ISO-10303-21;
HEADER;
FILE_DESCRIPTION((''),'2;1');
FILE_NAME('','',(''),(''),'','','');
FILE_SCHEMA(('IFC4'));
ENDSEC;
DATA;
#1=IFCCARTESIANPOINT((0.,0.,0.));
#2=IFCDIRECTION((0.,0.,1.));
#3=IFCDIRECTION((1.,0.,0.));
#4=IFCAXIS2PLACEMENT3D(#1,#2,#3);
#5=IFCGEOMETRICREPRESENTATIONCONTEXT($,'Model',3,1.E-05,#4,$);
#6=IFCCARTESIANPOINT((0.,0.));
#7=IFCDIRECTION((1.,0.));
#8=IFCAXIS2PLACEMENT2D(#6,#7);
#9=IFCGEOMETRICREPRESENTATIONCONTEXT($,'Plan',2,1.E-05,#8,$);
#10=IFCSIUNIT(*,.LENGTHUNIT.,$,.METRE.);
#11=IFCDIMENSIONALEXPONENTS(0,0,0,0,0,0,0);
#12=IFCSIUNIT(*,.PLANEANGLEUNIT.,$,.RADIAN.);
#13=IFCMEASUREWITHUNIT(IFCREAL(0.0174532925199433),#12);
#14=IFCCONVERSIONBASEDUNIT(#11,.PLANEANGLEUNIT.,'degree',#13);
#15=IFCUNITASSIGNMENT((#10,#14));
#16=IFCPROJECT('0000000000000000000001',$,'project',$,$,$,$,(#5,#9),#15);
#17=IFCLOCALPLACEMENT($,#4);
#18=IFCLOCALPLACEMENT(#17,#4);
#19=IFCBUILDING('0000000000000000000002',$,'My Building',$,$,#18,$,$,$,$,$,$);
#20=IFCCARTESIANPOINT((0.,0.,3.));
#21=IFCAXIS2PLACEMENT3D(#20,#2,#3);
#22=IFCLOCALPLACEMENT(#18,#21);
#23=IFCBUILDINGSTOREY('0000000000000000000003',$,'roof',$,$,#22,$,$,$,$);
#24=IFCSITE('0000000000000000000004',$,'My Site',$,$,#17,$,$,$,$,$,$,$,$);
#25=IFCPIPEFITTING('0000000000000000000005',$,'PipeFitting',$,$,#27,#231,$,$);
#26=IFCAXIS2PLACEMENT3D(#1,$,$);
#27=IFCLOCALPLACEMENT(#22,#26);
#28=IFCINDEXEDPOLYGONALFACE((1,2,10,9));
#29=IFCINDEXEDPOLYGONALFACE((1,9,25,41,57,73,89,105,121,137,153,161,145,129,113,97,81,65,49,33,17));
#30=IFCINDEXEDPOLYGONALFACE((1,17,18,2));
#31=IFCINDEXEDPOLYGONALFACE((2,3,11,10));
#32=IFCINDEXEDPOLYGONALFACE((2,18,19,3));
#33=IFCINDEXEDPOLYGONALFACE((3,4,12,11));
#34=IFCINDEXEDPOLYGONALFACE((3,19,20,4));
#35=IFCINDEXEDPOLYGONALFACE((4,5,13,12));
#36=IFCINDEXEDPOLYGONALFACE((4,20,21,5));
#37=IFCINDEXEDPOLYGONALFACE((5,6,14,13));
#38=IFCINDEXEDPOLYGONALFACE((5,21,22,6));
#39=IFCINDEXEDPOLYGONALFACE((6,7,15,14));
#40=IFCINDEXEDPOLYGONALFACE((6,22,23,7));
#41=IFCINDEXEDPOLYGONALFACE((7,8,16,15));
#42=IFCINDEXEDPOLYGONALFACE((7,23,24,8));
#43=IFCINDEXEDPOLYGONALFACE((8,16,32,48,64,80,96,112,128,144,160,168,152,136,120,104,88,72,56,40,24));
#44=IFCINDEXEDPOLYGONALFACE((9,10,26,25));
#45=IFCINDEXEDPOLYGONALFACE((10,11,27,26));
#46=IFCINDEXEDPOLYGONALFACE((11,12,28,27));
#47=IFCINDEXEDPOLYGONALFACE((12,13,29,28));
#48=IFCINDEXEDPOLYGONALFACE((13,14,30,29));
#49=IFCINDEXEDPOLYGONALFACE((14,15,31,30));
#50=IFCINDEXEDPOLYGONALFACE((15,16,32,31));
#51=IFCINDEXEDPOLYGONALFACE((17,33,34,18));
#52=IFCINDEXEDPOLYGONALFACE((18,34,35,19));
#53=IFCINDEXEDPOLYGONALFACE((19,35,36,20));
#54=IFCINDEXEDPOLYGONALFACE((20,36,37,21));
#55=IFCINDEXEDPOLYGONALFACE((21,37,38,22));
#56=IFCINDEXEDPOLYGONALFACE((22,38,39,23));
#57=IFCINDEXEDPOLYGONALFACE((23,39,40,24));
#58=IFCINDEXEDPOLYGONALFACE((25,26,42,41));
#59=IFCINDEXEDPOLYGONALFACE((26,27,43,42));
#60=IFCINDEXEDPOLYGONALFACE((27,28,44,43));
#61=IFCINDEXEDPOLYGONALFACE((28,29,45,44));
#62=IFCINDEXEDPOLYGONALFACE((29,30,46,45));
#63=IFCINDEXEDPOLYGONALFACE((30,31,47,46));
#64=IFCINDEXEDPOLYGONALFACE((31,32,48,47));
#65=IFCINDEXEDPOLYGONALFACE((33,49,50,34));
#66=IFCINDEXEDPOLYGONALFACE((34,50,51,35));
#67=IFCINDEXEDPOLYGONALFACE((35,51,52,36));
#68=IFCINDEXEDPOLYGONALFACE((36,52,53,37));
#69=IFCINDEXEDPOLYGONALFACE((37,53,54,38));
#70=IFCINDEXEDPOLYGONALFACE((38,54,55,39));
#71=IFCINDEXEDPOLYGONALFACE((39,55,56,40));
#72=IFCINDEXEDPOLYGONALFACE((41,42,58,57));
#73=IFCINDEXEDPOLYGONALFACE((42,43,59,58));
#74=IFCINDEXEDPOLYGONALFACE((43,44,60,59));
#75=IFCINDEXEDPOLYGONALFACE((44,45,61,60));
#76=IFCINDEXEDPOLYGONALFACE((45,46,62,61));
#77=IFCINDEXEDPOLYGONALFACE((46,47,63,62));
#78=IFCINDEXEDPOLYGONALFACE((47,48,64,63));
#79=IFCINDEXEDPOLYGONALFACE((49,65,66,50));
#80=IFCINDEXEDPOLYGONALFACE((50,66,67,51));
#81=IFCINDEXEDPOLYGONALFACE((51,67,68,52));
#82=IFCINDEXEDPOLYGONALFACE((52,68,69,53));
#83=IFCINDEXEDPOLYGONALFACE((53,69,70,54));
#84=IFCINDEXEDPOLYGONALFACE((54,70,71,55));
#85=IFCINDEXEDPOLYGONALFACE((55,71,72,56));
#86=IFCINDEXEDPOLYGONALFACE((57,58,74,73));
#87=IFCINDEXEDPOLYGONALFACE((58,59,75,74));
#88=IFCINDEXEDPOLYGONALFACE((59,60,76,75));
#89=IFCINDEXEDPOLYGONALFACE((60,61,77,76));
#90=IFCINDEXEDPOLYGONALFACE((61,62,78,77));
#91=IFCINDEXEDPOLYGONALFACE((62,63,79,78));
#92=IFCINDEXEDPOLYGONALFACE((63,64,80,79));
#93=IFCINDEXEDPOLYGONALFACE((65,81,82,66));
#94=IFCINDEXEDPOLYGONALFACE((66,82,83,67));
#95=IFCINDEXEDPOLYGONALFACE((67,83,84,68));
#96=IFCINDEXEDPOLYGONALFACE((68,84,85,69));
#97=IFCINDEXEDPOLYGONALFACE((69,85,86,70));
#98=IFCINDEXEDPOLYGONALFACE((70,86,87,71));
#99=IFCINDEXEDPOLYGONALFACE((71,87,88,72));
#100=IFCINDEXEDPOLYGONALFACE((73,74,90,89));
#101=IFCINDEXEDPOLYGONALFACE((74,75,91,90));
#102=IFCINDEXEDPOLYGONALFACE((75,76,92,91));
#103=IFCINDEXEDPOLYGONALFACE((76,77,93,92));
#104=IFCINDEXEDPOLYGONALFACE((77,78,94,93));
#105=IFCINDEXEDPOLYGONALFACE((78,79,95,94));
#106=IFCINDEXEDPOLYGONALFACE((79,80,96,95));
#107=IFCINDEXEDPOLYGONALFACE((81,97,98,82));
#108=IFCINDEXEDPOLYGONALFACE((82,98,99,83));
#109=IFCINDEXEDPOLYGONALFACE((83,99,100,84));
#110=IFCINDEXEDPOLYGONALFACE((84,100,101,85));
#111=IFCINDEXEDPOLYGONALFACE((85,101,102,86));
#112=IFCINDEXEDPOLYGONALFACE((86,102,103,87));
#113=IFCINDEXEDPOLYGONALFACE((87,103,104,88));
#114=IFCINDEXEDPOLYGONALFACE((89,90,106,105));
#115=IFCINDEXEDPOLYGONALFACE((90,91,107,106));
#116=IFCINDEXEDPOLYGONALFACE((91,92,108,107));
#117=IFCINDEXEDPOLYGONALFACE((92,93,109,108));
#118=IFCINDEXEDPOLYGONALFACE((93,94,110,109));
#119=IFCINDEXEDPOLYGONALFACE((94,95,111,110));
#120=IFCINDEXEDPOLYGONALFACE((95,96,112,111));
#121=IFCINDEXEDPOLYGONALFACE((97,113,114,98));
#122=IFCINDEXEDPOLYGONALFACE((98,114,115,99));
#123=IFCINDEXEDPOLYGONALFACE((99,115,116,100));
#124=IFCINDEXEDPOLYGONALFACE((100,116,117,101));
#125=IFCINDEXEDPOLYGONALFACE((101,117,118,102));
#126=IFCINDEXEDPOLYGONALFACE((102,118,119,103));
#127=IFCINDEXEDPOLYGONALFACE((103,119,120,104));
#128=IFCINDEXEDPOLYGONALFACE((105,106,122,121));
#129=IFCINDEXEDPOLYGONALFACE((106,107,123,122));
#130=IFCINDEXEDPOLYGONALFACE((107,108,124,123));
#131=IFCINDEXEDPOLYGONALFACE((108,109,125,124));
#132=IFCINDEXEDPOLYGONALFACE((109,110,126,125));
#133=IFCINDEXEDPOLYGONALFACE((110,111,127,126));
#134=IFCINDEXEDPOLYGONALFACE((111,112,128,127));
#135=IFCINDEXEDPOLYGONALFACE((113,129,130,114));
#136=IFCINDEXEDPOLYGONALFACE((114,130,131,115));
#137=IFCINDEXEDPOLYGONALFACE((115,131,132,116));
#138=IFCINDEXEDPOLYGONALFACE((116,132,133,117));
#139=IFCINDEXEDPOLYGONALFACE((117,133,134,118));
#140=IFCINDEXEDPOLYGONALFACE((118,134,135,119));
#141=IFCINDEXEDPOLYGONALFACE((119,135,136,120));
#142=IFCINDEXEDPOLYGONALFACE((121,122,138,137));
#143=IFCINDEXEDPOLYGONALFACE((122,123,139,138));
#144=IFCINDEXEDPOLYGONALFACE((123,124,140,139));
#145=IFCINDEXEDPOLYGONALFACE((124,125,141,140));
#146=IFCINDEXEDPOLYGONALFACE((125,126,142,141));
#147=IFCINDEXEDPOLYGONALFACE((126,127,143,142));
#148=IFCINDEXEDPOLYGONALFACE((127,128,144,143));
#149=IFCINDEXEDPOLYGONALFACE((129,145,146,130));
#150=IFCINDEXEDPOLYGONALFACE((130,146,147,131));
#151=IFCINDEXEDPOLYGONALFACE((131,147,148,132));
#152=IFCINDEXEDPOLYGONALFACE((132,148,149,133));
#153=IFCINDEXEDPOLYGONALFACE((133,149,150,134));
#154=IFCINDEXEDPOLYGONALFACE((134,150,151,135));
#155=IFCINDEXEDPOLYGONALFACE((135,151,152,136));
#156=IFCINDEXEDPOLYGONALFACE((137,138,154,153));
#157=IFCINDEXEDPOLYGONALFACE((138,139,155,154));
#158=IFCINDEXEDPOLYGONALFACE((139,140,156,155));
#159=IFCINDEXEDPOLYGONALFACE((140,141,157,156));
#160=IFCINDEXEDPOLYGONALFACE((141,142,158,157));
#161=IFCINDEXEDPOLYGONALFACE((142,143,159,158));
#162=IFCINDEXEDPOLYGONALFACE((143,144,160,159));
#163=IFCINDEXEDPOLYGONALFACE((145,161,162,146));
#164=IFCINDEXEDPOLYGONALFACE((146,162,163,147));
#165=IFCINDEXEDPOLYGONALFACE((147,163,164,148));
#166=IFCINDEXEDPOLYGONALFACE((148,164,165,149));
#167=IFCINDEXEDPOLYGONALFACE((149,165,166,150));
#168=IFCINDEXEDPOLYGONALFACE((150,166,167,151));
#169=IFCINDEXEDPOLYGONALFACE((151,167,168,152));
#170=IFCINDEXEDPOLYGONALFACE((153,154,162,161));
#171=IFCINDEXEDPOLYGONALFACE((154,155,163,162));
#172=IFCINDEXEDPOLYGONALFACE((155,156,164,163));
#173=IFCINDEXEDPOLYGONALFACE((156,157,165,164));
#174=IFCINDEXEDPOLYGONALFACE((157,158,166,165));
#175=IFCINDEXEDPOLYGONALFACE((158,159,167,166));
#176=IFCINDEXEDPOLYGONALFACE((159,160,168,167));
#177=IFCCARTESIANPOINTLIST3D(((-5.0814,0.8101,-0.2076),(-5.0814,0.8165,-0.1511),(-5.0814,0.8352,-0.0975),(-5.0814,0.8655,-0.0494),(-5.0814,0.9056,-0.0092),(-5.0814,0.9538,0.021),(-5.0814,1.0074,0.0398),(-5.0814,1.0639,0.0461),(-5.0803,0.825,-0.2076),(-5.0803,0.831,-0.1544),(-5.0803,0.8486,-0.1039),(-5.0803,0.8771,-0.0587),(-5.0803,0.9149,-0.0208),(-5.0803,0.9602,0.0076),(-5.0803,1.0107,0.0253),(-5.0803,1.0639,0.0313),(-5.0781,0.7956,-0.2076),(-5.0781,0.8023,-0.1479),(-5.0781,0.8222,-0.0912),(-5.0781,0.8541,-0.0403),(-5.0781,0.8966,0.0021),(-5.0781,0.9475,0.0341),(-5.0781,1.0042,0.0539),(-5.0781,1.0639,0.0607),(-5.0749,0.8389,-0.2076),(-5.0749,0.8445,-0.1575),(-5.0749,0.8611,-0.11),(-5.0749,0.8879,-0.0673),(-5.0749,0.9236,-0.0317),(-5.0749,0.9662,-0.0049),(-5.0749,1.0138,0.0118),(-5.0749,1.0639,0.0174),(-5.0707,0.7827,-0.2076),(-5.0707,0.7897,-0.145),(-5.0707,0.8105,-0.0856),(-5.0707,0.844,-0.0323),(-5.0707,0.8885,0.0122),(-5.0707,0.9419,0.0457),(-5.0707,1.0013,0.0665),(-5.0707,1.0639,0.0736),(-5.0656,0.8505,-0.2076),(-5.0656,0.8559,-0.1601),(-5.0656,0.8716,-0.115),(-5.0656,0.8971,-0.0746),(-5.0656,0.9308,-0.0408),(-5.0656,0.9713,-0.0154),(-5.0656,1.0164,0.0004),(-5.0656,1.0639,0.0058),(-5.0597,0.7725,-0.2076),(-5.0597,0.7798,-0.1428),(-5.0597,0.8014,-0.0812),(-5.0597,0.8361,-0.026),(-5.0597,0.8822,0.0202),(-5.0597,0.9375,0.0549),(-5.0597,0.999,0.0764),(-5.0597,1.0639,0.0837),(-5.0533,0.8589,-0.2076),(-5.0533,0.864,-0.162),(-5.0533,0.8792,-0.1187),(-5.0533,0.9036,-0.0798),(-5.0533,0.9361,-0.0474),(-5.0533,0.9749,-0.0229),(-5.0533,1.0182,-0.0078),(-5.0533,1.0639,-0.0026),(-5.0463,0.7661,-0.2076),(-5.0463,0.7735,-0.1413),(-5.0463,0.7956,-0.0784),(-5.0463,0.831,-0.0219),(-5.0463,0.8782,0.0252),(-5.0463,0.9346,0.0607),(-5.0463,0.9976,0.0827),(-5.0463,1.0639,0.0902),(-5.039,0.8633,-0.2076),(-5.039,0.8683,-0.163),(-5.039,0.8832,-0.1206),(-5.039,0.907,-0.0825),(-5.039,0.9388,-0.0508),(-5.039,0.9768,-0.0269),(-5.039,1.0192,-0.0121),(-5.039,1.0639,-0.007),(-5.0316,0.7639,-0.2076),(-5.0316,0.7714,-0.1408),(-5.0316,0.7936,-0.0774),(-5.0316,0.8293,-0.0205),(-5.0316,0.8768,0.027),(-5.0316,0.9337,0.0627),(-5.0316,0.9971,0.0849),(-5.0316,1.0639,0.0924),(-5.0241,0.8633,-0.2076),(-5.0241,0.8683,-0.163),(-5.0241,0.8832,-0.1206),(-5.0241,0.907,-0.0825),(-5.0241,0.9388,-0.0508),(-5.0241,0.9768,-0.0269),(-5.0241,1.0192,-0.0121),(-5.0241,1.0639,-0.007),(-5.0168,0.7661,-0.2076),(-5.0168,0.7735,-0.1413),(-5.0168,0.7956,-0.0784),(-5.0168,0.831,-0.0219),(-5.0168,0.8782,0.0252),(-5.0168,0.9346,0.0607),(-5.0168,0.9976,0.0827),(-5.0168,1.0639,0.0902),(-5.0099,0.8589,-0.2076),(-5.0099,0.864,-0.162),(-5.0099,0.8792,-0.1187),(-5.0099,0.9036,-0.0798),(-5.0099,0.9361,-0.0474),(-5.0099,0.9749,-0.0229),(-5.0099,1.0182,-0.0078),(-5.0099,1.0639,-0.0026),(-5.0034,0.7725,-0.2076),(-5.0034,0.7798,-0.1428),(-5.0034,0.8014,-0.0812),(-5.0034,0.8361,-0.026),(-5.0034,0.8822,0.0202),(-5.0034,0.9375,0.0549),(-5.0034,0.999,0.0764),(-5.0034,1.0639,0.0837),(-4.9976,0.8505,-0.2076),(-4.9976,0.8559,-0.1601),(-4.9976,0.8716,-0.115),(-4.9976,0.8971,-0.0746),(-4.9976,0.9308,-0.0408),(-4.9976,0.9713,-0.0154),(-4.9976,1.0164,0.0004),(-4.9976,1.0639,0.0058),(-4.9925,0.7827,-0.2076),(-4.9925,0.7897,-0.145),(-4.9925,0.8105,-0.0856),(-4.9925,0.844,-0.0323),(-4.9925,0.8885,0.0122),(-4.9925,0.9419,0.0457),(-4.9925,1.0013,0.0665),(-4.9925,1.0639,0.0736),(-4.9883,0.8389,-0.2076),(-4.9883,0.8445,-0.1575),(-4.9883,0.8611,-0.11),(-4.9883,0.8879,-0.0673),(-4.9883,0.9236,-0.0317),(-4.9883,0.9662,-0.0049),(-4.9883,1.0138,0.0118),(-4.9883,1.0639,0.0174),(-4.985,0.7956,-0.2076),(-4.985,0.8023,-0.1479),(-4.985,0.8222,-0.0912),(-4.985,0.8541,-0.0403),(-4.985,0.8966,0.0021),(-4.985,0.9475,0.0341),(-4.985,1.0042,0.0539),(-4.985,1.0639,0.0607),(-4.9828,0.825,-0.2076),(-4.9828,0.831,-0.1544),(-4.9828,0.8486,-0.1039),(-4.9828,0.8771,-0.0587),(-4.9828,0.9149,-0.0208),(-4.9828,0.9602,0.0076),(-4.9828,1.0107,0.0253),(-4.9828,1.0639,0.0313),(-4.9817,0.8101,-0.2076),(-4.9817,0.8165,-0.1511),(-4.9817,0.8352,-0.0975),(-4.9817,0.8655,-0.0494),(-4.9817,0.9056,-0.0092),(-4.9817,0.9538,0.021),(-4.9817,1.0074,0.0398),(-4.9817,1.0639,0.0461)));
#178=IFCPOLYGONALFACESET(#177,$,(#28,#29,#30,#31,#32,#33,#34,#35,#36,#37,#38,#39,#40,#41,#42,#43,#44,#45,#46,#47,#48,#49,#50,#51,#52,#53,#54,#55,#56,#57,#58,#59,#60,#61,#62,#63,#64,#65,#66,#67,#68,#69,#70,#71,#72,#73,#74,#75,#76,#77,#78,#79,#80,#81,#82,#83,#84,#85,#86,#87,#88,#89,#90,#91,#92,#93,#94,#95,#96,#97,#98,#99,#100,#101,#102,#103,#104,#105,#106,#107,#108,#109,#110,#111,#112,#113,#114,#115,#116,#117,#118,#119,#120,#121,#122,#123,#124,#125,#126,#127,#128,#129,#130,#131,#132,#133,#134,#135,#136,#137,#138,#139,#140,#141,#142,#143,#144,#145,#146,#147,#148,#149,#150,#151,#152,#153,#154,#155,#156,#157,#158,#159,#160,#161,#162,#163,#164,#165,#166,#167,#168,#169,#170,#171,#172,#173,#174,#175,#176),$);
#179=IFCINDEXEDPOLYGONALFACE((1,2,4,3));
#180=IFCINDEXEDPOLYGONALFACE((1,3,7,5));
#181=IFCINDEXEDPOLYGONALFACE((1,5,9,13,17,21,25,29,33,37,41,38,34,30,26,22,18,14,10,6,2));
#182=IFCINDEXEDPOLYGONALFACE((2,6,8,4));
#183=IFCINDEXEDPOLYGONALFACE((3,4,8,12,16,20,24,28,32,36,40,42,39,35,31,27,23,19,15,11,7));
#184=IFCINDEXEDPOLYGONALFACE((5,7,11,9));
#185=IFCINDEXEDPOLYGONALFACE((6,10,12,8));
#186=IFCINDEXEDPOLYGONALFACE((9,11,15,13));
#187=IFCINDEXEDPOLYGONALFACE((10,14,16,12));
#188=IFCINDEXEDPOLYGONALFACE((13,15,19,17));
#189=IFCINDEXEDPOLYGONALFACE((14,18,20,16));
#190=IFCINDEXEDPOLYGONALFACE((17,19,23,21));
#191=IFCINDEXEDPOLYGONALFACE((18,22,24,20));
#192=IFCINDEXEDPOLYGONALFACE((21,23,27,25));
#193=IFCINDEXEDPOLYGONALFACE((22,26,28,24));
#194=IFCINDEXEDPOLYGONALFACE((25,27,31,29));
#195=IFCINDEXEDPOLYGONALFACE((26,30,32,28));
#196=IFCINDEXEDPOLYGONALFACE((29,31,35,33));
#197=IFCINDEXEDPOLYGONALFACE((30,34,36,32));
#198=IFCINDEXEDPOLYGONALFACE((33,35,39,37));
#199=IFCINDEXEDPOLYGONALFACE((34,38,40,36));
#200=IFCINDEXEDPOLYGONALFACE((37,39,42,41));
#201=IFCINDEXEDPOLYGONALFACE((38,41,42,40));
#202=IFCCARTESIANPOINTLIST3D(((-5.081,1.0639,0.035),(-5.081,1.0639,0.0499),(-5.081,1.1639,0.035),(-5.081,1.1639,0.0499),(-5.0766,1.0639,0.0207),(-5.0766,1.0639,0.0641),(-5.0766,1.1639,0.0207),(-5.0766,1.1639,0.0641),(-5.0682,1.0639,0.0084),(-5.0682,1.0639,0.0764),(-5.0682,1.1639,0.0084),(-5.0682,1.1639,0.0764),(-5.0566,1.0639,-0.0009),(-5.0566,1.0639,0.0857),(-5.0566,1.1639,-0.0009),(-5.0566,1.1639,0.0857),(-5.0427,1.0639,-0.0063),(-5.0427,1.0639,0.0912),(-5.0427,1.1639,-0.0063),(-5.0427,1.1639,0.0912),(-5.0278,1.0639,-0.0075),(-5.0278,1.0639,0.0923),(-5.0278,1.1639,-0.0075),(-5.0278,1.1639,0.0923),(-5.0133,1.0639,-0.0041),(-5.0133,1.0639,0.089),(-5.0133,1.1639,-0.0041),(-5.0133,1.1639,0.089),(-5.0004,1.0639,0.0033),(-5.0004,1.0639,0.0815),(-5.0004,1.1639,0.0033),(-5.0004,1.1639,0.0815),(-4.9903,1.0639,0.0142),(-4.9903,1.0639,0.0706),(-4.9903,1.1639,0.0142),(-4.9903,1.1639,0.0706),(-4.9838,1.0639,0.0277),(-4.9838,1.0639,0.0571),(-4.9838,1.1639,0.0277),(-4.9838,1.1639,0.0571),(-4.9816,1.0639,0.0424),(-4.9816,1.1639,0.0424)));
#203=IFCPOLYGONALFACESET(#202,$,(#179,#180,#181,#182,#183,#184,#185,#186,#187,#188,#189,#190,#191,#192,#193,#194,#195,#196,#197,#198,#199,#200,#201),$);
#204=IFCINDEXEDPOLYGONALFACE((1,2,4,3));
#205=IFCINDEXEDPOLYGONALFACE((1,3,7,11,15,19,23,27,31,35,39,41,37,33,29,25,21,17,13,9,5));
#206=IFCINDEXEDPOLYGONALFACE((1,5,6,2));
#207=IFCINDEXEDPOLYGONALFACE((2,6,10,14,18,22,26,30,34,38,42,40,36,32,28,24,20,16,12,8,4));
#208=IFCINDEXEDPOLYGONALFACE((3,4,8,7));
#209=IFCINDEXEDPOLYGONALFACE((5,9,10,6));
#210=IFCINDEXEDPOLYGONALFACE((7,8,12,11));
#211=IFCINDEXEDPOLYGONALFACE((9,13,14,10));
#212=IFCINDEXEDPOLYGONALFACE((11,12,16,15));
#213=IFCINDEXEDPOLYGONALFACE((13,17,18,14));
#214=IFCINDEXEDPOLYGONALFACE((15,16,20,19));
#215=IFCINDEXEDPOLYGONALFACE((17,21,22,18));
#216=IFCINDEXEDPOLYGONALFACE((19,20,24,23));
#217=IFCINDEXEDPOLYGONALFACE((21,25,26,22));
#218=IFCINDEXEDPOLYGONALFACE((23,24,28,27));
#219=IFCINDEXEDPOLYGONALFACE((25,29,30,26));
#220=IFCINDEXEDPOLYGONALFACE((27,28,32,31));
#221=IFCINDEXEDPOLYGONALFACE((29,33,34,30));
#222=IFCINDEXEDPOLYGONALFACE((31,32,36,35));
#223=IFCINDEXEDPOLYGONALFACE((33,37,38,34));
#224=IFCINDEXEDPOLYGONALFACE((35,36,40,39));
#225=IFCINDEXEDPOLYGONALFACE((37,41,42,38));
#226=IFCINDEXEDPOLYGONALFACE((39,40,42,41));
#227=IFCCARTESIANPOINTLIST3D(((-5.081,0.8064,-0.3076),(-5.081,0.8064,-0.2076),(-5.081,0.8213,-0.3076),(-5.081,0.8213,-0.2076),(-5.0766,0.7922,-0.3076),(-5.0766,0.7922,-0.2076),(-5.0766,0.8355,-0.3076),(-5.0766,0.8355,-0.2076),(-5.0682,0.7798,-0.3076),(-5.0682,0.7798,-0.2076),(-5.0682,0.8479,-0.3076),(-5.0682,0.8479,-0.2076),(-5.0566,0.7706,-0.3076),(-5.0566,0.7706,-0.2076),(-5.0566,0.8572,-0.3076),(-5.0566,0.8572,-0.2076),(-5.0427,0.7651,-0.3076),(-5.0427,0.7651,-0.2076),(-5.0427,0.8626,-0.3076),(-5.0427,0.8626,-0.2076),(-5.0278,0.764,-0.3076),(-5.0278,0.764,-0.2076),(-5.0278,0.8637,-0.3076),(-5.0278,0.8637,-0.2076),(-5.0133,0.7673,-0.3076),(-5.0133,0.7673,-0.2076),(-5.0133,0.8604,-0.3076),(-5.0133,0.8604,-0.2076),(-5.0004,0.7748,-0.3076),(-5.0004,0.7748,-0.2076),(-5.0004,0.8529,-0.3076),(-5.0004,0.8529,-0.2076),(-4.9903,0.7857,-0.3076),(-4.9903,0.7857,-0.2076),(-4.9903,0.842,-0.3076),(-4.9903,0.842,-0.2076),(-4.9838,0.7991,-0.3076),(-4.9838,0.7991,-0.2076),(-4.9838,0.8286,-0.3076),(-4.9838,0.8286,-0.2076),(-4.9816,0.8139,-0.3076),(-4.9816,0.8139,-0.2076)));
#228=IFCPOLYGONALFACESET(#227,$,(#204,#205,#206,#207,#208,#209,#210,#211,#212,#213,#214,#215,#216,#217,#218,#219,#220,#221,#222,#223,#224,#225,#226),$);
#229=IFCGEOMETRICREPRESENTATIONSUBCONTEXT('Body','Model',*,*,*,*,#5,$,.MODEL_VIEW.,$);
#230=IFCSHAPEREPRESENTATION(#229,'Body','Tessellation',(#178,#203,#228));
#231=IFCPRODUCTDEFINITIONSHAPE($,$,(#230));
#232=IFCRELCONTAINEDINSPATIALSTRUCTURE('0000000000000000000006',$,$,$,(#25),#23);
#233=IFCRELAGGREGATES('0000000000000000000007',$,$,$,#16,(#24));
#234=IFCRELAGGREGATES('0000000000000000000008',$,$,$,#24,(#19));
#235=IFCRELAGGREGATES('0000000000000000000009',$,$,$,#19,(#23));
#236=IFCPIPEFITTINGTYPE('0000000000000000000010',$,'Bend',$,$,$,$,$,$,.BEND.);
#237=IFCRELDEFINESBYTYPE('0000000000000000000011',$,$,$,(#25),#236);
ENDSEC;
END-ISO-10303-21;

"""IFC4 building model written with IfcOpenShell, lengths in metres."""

from ifc_helpers import new_model, entity, si_unit, converted_unit, frame, origin_with_axes, origin_2d_with_axis, place, context, subcontext, project, spatial, circle, extrude, source, transform, mapped, type_object, type_shapes, element, save


model = new_model("IFC4")

# Units and contexts
model_context = context("Model", 3, precision=1e-05, world=origin_with_axes())
plan_context = context("Plan", 2, precision=1e-05, world=origin_2d_with_axis())
body_context = subcontext(model_context, "Body", "Model", "MODEL_VIEW")
ifc_project = project(units=[si_unit("LENGTHUNIT", "METRE"), converted_unit("PLANEANGLEUNIT", "degree", entity("IfcReal", 0.0174532925199433), si_unit("PLANEANGLEUNIT", "RADIAN"), dimensions=[0, 0, 0, 0, 0, 0, 0])], contexts=[model_context, plan_context])

# Site, building, storey
site_placement = place(None, origin_with_axes())
site = spatial("IfcSite", under=ifc_project, at=site_placement, Name="My Site")
building_placement = place(site_placement, origin_with_axes())
building = spatial("IfcBuilding", under=site, at=building_placement, Name="My Building")
storey_placement = place(building_placement, frame((0.0, 0.0, 3.0), z_axis=(0.0, 0.0, 1.0), x_axis=(1.0, 0.0, 0.0)))
storey = spatial("IfcBuildingStorey", under=building, at=storey_placement, Name="roof")

# Pipe fitting
pipe_fitting_type_1 = type_object("IfcPipeFittingType", Name="Bend", PredefinedType="BEND")
shared_shape_1 = source(origin_with_axes(), body_context, "Body", "SolidModel", [
    entity("IfcSweptDiskSolid", entity("IfcIndexedPolyCurve", entity("IfcCartesianPointList3D", [[0.0, 0.0, 0.1], [0.0, -0.0732, 0.2768], [0.0, -0.25, 0.35]]), [entity("IfcArcIndex", [1, 2, 3])]), 0.05),
    extrude(circle(Radius=0.05), origin_with_axes(), (0.0, 0.0, 1.0), 0.1),
    extrude(circle(Radius=0.05), frame((0.0, -0.25, 0.35), z_axis=(0.0, -1.0, 0.000008), x_axis=(1.0, 0.0, 0.0)), (0.0, 0.0, 1.0), 0.1),
])
type_shapes(pipe_fitting_type_1, [shared_shape_1])
for number, where, z_axis, x_axis, name in (
    (1, (-5.0316, 1.1639, 0.0424), (0.0, -1.0, -0.000008), (1.0, 0.0, 0.0), "PipeFitting"),
):
    element("IfcPipeFitting", number, at=place(storey_placement, frame(where, z_axis=z_axis, x_axis=x_axis)), inside=storey, type_object=pipe_fitting_type_1, Name=name, context=body_context, shape_type="MappedRepresentation", body=[
        mapped(shared_shape_1, transform((0.0, 0.0, 0.0), x_axis=(1.0, 0.0, 0.0), y_axis=(0.0, 1.0, 0.0), z_axis=(0.0, 0.0, 1.0), scale=1.0)),
    ])

save(model, "model.ifc")
